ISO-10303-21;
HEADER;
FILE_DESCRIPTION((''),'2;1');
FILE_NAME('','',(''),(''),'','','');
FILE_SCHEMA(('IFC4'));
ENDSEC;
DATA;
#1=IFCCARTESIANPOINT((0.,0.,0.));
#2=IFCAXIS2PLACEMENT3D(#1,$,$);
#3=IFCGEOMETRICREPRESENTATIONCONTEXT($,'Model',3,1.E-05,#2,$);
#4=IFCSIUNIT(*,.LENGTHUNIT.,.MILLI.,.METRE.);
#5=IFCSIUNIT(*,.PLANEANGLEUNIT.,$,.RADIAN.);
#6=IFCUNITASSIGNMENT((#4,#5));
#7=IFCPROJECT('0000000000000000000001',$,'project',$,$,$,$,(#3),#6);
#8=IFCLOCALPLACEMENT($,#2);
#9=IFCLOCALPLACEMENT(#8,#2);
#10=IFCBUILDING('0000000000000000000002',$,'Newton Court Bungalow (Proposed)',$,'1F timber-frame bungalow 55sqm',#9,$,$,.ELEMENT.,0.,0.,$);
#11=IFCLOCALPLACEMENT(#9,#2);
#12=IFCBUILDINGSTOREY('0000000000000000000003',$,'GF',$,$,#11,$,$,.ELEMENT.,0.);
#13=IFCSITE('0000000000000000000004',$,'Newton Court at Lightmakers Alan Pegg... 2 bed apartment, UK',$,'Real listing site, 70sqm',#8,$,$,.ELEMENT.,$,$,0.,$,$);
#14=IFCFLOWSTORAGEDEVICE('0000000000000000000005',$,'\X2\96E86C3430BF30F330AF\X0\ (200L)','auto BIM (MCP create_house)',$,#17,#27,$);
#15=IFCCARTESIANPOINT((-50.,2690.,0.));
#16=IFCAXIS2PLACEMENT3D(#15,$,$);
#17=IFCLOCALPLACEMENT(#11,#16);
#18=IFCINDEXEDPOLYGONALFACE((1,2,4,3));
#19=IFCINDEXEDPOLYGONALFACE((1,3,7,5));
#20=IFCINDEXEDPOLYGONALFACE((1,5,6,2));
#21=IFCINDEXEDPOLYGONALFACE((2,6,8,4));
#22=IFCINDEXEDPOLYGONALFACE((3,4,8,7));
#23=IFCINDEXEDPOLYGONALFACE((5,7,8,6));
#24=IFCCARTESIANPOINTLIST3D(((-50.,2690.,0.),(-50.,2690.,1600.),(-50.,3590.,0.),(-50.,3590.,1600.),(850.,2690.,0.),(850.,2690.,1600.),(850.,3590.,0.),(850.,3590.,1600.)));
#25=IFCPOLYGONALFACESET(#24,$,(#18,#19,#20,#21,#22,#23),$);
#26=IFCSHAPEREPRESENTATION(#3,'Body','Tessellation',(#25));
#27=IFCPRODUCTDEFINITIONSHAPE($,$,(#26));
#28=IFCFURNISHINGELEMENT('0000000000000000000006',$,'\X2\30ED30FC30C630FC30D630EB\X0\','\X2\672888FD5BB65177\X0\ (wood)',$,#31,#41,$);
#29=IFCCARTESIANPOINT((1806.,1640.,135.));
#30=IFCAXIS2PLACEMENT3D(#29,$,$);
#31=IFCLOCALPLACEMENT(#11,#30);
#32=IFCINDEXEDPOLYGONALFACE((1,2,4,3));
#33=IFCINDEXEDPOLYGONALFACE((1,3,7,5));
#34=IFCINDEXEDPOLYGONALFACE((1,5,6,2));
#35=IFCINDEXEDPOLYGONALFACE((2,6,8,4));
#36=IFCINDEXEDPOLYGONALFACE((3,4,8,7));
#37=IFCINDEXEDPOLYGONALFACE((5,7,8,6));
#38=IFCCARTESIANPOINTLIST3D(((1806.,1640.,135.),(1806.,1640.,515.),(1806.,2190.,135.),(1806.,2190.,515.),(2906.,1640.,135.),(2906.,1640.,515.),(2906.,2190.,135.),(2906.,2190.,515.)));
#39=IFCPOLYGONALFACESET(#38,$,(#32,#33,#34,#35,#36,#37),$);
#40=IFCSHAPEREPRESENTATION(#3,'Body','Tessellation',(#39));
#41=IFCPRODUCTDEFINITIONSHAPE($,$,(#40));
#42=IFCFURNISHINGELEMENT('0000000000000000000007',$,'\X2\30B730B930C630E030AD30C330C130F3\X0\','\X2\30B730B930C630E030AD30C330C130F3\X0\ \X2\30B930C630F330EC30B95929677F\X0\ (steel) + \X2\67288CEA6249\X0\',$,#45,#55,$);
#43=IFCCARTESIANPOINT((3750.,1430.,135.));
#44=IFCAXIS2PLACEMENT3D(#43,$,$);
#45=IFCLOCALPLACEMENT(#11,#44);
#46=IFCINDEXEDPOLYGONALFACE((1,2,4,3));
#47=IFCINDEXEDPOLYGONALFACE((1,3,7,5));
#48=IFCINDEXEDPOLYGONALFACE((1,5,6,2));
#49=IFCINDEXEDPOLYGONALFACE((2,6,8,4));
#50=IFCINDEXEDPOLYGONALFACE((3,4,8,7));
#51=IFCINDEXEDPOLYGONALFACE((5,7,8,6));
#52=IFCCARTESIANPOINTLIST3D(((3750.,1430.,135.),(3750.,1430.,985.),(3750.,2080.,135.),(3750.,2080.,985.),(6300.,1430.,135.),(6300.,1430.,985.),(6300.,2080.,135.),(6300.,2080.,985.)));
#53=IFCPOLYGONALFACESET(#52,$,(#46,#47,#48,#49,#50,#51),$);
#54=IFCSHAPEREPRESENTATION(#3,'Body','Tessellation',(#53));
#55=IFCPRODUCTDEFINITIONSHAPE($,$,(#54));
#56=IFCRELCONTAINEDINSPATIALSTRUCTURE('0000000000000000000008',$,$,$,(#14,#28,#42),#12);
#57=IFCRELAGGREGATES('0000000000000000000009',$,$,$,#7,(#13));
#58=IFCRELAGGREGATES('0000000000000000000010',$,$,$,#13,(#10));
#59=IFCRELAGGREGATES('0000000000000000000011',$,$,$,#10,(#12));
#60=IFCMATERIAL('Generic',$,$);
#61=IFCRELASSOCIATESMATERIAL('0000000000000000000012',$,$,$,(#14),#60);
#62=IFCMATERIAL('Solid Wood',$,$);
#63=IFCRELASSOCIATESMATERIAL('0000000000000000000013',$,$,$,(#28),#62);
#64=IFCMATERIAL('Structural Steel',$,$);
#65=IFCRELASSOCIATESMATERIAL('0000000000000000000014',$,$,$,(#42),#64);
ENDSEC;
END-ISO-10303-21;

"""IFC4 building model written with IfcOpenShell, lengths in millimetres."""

from ifc_helpers import new_model, si_unit, frame, frame_2d, origin, place, context, project, spatial, rectangle, extrude, material, element, save


model = new_model("IFC4")

# Units and contexts
model_context = context("Model", 3, precision=1e-05, world=origin())
ifc_project = project(units=[si_unit("LENGTHUNIT", "METRE", prefix="MILLI"), si_unit("PLANEANGLEUNIT", "RADIAN")], contexts=[model_context])

# Site, building, storey
site_placement = place(None, origin())
site = spatial("IfcSite", under=ifc_project, at=site_placement, Name="Newton Court at Lightmakers Alan Pegg... 2 bed apartment, UK", ObjectType="Real listing site, 70sqm", CompositionType="ELEMENT", RefElevation=0.0)
building_placement = place(site_placement, origin())
building = spatial("IfcBuilding", under=site, at=building_placement, Name="Newton Court Bungalow (Proposed)", ObjectType="1F timber-frame bungalow 55sqm", CompositionType="ELEMENT", ElevationOfRefHeight=0.0, ElevationOfTerrain=0.0)
storey_placement = place(building_placement, origin())
storey = spatial("IfcBuildingStorey", under=building, at=storey_placement, Name="GF", CompositionType="ELEMENT", Elevation=0.0)

# Shared definitions
ifc_material_1 = material(Name="Solid Wood")

# Shared definitions
ifc_material_2 = material(Name="Generic")

# Flow storage device
flow_storage_device_placement = place(storey_placement, frame((-50.0, 2690.0, 0.0)))
element("IfcFlowStorageDevice", 1, at=flow_storage_device_placement, inside=storey, material=ifc_material_2, Name="雨水タンク (200L)", Description="auto BIM (MCP create_house)", context=model_context, shape_type="SweptSolid", body=[
    extrude(rectangle(XDim=900.0, YDim=900.0, at=frame_2d((450.0, 450.0))), frame((-50.0, 2690.0, 0.0)), (0.0, 0.0, 1.0), 1600.0),
])

# Furnishing elements
furnishing_1_placement = place(storey_placement, frame((1806.0, 1640.0, 135.0)))
element("IfcFurnishingElement", 2, at=furnishing_1_placement, inside=storey, material=ifc_material_1, Name="ローテーブル", Description="木製家具 (wood)", context=model_context, shape_type="SweptSolid", body=[
    extrude(rectangle(XDim=1100.0, YDim=550.0, at=frame_2d((550.0, 275.0))), frame((1806.0, 1640.0, 135.0)), (0.0, 0.0, 1.0), 380.0),
])
ifc_material_3 = material(Name="Structural Steel")
furnishing_2_placement = place(storey_placement, frame((3750.0, 1430.0, 135.0)))
element("IfcFurnishingElement", 3, at=furnishing_2_placement, inside=storey, material=ifc_material_3, Name="システムキッチン", Description="システムキッチン ステンレス天板 (steel) + 木質扉", context=model_context, shape_type="SweptSolid", body=[
    extrude(rectangle(XDim=2550.0, YDim=650.0, at=frame_2d((1275.0, 325.0))), frame((3750.0, 1430.0, 135.0)), (0.0, 0.0, 1.0), 850.0),
])

save(model, "model.ifc")
